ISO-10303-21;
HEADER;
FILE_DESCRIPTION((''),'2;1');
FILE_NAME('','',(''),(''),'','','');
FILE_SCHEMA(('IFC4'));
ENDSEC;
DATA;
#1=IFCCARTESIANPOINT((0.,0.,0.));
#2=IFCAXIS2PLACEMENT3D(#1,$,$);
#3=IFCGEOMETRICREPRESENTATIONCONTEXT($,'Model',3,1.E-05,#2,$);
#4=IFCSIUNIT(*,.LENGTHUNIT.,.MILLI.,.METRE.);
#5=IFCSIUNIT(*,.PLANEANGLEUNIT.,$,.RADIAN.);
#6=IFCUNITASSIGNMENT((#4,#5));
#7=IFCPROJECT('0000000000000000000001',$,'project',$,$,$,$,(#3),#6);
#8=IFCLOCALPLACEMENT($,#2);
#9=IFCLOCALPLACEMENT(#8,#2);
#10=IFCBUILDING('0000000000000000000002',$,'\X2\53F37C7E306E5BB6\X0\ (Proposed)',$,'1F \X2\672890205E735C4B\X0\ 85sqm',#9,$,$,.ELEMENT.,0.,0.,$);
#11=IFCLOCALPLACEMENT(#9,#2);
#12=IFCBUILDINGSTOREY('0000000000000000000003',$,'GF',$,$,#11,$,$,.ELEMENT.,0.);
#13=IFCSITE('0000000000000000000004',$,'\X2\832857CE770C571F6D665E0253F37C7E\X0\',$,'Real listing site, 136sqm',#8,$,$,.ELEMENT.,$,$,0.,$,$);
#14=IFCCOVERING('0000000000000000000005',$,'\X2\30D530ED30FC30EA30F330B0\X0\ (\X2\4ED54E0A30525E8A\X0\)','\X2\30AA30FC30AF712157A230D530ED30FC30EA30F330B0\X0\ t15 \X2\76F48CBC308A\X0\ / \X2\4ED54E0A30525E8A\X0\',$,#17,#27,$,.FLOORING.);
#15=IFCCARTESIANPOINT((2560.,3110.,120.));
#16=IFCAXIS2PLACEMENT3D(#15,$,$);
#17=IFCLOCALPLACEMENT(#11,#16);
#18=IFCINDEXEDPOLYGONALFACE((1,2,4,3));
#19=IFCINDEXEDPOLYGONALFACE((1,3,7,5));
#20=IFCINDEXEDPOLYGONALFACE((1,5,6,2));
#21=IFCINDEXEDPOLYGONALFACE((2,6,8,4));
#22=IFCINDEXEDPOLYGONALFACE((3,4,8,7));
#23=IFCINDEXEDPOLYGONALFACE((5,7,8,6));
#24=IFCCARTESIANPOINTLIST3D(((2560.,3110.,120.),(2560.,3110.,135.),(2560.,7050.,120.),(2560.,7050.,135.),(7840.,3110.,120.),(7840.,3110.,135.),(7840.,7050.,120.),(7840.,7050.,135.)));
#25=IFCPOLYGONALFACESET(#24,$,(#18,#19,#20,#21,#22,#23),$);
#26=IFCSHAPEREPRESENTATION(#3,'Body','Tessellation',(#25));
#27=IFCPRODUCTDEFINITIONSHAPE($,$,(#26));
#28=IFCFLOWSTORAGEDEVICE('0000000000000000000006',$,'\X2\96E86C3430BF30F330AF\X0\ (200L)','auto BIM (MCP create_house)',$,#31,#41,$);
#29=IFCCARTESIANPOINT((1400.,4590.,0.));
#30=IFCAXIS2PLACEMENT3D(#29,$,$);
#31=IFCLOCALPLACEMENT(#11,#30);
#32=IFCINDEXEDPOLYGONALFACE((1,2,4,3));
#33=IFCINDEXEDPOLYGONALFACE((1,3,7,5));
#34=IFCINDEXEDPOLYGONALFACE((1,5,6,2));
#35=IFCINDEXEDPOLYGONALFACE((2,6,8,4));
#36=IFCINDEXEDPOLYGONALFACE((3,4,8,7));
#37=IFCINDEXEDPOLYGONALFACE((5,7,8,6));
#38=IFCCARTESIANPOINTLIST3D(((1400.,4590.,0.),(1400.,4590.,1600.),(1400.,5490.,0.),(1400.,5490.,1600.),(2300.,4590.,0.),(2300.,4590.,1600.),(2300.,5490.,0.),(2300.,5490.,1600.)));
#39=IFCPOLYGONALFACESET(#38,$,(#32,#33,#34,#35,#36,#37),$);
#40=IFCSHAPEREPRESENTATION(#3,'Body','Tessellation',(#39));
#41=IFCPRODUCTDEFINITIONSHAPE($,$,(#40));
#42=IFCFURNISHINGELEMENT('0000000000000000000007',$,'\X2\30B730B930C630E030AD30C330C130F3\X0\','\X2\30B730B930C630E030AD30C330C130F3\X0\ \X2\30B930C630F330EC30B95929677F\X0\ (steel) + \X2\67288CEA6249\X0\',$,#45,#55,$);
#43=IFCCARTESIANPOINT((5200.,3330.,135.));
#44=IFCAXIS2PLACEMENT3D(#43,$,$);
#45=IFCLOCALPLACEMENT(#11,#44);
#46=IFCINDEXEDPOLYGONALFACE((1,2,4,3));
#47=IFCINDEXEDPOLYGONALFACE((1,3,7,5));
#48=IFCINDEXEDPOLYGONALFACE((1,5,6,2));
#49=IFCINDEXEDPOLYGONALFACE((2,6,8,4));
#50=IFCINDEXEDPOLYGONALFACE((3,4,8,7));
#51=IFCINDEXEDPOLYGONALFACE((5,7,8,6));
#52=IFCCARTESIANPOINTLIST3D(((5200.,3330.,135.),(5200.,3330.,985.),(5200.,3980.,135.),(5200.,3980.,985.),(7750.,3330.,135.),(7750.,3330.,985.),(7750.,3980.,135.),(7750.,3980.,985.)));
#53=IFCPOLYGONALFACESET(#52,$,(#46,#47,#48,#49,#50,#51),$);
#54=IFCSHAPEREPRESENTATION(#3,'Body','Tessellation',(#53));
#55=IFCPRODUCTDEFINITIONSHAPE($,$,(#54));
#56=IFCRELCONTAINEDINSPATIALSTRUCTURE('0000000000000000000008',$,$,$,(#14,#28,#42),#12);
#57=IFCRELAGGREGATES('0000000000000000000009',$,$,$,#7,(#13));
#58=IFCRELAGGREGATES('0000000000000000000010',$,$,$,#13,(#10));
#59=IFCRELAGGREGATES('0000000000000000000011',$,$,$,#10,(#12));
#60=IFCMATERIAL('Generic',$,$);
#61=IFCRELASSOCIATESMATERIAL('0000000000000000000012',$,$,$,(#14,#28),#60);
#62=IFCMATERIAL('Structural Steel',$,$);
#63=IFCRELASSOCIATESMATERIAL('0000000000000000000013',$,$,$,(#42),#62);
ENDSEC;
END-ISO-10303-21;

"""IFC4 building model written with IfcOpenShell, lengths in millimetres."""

from ifc_helpers import new_model, si_unit, frame, frame_2d, origin, place, context, project, spatial, rectangle, extrude, material, element, save


model = new_model("IFC4")

# Units and contexts
model_context = context("Model", 3, precision=1e-05, world=origin())
ifc_project = project(units=[si_unit("LENGTHUNIT", "METRE", prefix="MILLI"), si_unit("PLANEANGLEUNIT", "RADIAN")], contexts=[model_context])

# Site, building, storey
site_placement = place(None, origin())
site = spatial("IfcSite", under=ifc_project, at=site_placement, Name="茨城県土浦市右籾", ObjectType="Real listing site, 136sqm", CompositionType="ELEMENT", RefElevation=0.0)
building_placement = place(site_placement, origin())
building = spatial("IfcBuilding", under=site, at=building_placement, Name="右籾の家 (Proposed)", ObjectType="1F 木造平屋 85sqm", CompositionType="ELEMENT", ElevationOfRefHeight=0.0, ElevationOfTerrain=0.0)
storey_placement = place(building_placement, origin())
storey = spatial("IfcBuildingStorey", under=building, at=storey_placement, Name="GF", CompositionType="ELEMENT", Elevation=0.0)

# Shared definitions
ifc_material_1 = material(Name="Generic")

# Covering
covering_placement = place(storey_placement, frame((2560.0, 3110.0, 120.0)))
element("IfcCovering", 1, at=covering_placement, inside=storey, material=ifc_material_1, Name="フローリング (仕上げ床)", Description="オーク無垢フローリング t15 直貼り / 仕上げ床", PredefinedType="FLOORING", context=model_context, shape_type="SweptSolid", body=[
    extrude(rectangle(XDim=5280.0, YDim=3940.0, at=frame_2d((2640.0, 1970.0))), frame((2560.0, 3110.0, 120.0)), (0.0, 0.0, 1.0), 15.0),
])

# Flow storage device
flow_storage_device_placement = place(storey_placement, frame((1400.0, 4590.0, 0.0)))
element("IfcFlowStorageDevice", 2, at=flow_storage_device_placement, inside=storey, material=ifc_material_1, Name="雨水タンク (200L)", Description="auto BIM (MCP create_house)", context=model_context, shape_type="SweptSolid", body=[
    extrude(rectangle(XDim=900.0, YDim=900.0, at=frame_2d((450.0, 450.0))), frame((1400.0, 4590.0, 0.0)), (0.0, 0.0, 1.0), 1600.0),
])

# Furnishing element
ifc_material_2 = material(Name="Structural Steel")
furnishing_placement = place(storey_placement, frame((5200.0, 3330.0, 135.0)))
element("IfcFurnishingElement", 3, at=furnishing_placement, inside=storey, material=ifc_material_2, Name="システムキッチン", Description="システムキッチン ステンレス天板 (steel) + 木質扉", context=model_context, shape_type="SweptSolid", body=[
    extrude(rectangle(XDim=2550.0, YDim=650.0, at=frame_2d((1275.0, 325.0))), frame((5200.0, 3330.0, 135.0)), (0.0, 0.0, 1.0), 850.0),
])

save(model, "model.ifc")
